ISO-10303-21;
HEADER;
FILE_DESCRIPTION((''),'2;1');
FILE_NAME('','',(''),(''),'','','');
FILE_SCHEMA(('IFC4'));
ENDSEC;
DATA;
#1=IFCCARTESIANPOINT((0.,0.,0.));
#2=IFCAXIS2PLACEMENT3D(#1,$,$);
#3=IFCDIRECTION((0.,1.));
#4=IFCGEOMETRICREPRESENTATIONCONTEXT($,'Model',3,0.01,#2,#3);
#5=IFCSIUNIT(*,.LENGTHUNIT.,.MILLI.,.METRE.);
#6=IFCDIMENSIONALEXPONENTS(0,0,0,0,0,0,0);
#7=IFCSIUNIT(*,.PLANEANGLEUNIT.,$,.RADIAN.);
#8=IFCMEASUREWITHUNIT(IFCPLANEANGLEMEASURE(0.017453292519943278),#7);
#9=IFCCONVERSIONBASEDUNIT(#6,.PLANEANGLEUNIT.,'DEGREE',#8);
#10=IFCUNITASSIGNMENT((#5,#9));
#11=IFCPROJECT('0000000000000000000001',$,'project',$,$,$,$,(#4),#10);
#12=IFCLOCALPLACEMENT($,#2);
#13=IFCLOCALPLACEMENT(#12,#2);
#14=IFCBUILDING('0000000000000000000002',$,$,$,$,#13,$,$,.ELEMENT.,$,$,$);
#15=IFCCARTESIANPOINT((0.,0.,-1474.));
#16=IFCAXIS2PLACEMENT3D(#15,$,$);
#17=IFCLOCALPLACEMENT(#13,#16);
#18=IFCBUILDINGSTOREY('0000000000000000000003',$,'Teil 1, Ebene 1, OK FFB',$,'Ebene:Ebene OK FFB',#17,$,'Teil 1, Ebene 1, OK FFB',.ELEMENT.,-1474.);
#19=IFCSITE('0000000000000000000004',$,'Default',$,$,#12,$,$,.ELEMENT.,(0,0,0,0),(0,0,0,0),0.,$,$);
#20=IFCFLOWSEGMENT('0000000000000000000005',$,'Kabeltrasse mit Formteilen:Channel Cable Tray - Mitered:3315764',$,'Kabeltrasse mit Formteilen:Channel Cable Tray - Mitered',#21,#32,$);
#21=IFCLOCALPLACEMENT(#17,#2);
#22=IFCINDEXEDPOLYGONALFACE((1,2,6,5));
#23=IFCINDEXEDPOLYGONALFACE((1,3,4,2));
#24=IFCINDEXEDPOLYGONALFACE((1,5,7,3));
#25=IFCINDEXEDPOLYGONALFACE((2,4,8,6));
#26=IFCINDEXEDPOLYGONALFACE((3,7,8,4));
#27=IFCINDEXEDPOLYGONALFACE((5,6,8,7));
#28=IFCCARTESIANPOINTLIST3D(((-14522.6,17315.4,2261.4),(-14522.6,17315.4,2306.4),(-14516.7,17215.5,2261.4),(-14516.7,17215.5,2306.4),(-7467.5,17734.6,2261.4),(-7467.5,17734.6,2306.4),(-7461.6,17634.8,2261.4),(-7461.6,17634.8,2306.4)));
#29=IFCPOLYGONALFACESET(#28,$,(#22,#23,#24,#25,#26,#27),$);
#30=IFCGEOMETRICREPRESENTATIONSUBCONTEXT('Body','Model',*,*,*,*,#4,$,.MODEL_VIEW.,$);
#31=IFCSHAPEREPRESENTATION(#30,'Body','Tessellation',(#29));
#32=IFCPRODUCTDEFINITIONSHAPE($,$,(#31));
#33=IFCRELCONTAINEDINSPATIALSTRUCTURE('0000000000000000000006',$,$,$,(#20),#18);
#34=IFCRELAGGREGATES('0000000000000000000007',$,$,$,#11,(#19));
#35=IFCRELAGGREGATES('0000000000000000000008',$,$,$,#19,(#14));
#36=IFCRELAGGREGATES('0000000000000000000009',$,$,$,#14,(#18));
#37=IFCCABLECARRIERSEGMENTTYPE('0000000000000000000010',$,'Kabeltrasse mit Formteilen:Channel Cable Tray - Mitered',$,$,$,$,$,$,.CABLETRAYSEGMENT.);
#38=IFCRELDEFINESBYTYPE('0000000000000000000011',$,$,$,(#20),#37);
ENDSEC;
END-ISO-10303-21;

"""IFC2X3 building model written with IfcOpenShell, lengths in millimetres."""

from ifc_helpers import new_model, entity, si_unit, converted_unit, direction, frame, frame_2d, origin, place, context, subcontext, project, spatial, rectangle, extrude, type_object, element, save


model = new_model("IFC2X3")

# Units and contexts
model_context = context("Model", 3, precision=0.01, world=origin(), true_north=direction((0.0, 1.0)))
body_context = subcontext(model_context, "Body", "Model", "MODEL_VIEW")
ifc_project = project(units=[si_unit("LENGTHUNIT", "METRE", prefix="MILLI"), converted_unit("PLANEANGLEUNIT", "DEGREE", entity("IfcPlaneAngleMeasure", 0.017453292519943278), si_unit("PLANEANGLEUNIT", "RADIAN"), dimensions=[0, 0, 0, 0, 0, 0, 0])], contexts=[model_context])

# Site, building, storey
site_placement = place(None, origin())
site = spatial("IfcSite", under=ifc_project, at=site_placement, Name="Default", CompositionType="ELEMENT", RefLatitude=(0, 0, 0, 0), RefLongitude=(0, 0, 0, 0), RefElevation=0.0)
building_placement = place(site_placement, origin())
building = spatial("IfcBuilding", under=site, at=building_placement, CompositionType="ELEMENT")
storey_placement = place(building_placement, frame((0.0, 0.0, -1474.0)))
storey = spatial("IfcBuildingStorey", under=building, at=storey_placement, Name="Teil 1, Ebene 1, OK FFB", ObjectType="Ebene:Ebene OK FFB", LongName="Teil 1, Ebene 1, OK FFB", CompositionType="ELEMENT", Elevation=-1474.0)

# Flow segment
cable_carrier_segment_type = type_object("IfcCableCarrierSegmentType", Name="Kabeltrasse mit Formteilen:Channel Cable Tray - Mitered", PredefinedType="CABLETRAYSEGMENT")
flow_segment_1_placement = place(storey_placement, origin())
element("IfcFlowSegment", 1, at=flow_segment_1_placement, inside=storey, type_object=cable_carrier_segment_type, Name="Kabeltrasse mit Formteilen:Channel Cable Tray - Mitered:3315764", ObjectType="Kabeltrasse mit Formteilen:Channel Cable Tray - Mitered", context=body_context, shape_type="SweptSolid", body=[
    extrude(rectangle(XDim=7067.6, YDim=100.0, at=frame_2d((0.0, 0.0), x_axis=(1.0, 0.0))), frame((-10992.1, 17475.1, 2261.4), z_axis=(0.0, 0.0, 1.0), x_axis=(-0.998239, -0.059319, 0.0)), (0.0, 0.0, 1.0), 45.0),
])

save(model, "model.ifc")
